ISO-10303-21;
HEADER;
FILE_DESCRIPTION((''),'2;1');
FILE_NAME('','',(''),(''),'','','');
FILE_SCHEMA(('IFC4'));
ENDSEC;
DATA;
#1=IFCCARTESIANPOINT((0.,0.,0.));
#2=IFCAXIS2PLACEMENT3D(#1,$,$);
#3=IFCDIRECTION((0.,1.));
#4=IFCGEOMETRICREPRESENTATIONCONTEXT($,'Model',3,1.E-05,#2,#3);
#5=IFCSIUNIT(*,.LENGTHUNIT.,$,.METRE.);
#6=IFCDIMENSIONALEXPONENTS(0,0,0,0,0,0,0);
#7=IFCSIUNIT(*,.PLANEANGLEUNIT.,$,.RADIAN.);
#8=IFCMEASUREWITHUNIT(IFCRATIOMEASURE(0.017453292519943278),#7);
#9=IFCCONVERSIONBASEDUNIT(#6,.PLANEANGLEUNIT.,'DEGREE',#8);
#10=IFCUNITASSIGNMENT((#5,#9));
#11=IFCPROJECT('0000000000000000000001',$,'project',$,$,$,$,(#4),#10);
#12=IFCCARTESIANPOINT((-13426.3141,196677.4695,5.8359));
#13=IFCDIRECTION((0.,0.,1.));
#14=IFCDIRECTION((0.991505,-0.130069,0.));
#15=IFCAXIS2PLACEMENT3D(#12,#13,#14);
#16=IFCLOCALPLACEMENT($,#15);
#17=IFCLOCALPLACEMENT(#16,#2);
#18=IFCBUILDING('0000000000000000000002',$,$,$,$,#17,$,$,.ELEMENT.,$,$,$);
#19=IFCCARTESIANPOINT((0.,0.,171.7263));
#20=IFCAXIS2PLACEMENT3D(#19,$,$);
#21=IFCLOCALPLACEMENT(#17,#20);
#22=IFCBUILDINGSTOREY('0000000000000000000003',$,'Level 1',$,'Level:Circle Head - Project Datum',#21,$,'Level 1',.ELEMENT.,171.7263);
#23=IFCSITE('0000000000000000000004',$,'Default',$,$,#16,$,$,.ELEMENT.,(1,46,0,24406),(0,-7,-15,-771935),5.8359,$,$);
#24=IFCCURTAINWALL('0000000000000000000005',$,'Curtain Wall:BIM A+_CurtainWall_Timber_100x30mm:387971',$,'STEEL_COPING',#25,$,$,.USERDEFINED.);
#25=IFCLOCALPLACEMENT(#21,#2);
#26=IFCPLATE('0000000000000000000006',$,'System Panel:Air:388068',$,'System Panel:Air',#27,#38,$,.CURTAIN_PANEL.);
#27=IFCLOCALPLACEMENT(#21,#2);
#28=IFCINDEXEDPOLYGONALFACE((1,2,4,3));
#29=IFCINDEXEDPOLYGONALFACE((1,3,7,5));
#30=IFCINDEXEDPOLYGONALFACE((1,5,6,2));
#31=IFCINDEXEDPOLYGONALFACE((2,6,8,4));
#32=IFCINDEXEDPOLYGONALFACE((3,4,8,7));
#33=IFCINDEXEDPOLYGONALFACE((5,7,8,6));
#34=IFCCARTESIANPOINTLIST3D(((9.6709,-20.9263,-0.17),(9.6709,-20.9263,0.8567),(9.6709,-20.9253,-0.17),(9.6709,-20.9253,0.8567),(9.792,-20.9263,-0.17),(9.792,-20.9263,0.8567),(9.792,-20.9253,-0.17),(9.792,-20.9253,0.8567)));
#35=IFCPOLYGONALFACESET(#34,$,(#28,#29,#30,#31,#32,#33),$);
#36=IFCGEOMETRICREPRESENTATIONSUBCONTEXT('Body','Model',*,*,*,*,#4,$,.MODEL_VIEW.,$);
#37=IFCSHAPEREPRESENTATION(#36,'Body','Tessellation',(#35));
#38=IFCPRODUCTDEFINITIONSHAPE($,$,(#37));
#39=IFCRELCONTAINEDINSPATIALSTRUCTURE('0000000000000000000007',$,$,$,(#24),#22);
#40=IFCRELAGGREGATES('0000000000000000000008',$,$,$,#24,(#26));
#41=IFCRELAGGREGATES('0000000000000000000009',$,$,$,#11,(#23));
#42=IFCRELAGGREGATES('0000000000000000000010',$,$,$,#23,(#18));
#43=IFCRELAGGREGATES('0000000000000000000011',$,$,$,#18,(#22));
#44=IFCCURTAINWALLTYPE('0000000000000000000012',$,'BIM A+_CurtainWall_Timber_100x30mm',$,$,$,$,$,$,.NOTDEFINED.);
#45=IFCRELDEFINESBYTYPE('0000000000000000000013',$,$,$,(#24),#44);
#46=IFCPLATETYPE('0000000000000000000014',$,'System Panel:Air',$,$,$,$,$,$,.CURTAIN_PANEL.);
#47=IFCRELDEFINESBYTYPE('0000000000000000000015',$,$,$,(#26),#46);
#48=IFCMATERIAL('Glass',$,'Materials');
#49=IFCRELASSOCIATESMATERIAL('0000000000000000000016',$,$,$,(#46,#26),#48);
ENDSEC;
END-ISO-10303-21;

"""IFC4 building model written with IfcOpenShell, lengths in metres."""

from ifc_helpers import new_model, entity, si_unit, converted_unit, direction, frame, origin, place, context, subcontext, project, spatial, indexed_curve, outline, extrude, source, transform, mapped, material, type_object, type_shapes, element, aggregate, save


model = new_model("IFC4")

# Units and contexts
model_context = context("Model", 3, precision=1e-05, world=origin(), true_north=direction((0.0, 1.0)))
body_context = subcontext(model_context, "Body", "Model", "MODEL_VIEW")
ifc_project = project(units=[si_unit("LENGTHUNIT", "METRE"), converted_unit("PLANEANGLEUNIT", "DEGREE", entity("IfcRatioMeasure", 0.017453292519943278), si_unit("PLANEANGLEUNIT", "RADIAN"), dimensions=[0, 0, 0, 0, 0, 0, 0])], contexts=[model_context])

# Site, building, storey
site_placement = place(None, frame((-13426.3141, 196677.4695, 5.8359), z_axis=(0.0, 0.0, 1.0), x_axis=(0.991505, -0.130069, 0.0)))
site = spatial("IfcSite", under=ifc_project, at=site_placement, Name="Default", CompositionType="ELEMENT", RefLatitude=(1, 46, 0, 24406), RefLongitude=(0, -7, -15, -771935), RefElevation=5.8359)
building_placement = place(site_placement, origin())
building = spatial("IfcBuilding", under=site, at=building_placement, CompositionType="ELEMENT")
storey_placement = place(building_placement, frame((0.0, 0.0, 171.7263)))
storey = spatial("IfcBuildingStorey", under=building, at=storey_placement, Name="Level 1", ObjectType="Level:Circle Head - Project Datum", LongName="Level 1", CompositionType="ELEMENT", Elevation=171.7263)

# Shared definitions
ifc_material_1 = material(Name="Glass", Category="Materials")

# Curtain wall, plate
curtain_wall_type_1 = type_object("IfcCurtainWallType", Name="BIM A+_CurtainWall_Timber_100x30mm", PredefinedType="NOTDEFINED")
curtain_wall_1_placement = place(storey_placement, frame((0.0, 0.0, -171.7263)))
curtain_wall_1 = element("IfcCurtainWall", 1, at=curtain_wall_1_placement, inside=storey, type_object=curtain_wall_type_1, Name="Curtain Wall:BIM A+_CurtainWall_Timber_100x30mm:387971", ObjectType="STEEL_COPING", PredefinedType="USERDEFINED")
plate_type_1 = type_object("IfcPlateType", Name="System Panel:Air", PredefinedType="CURTAIN_PANEL", material=ifc_material_1)
shared_shape_1 = source(origin(), body_context, "Body", "SweptSolid", [
    extrude(outline(indexed_curve([(-0.0005, -0.0606), (0.0005, -0.0606), (0.0005, 0.0606), (-0.0005, 0.0606), (-0.0005, -0.0606)], self_intersect=False)), frame((0.0, 0.0, 0.0), z_axis=(0.0, 0.0, 1.0), x_axis=(0.0, 1.0, 0.0)), (0.0, 0.0, 1.0), 1.0267),
])
type_shapes(plate_type_1, [shared_shape_1])
plate_1_placement = place(curtain_wall_1_placement, frame((9.7315, -20.9258, 171.5563)))
plate_1 = element("IfcPlate", 2, at=plate_1_placement, type_object=plate_type_1, material=ifc_material_1, Name="System Panel:Air:388068", ObjectType="System Panel:Air", PredefinedType="CURTAIN_PANEL", context=body_context, shape_type="MappedRepresentation", body=[
    mapped(shared_shape_1, transform((0.0, 0.0, 0.0), scale=1.0)),
])
aggregate(curtain_wall_1, [plate_1])

save(model, "model.ifc")
